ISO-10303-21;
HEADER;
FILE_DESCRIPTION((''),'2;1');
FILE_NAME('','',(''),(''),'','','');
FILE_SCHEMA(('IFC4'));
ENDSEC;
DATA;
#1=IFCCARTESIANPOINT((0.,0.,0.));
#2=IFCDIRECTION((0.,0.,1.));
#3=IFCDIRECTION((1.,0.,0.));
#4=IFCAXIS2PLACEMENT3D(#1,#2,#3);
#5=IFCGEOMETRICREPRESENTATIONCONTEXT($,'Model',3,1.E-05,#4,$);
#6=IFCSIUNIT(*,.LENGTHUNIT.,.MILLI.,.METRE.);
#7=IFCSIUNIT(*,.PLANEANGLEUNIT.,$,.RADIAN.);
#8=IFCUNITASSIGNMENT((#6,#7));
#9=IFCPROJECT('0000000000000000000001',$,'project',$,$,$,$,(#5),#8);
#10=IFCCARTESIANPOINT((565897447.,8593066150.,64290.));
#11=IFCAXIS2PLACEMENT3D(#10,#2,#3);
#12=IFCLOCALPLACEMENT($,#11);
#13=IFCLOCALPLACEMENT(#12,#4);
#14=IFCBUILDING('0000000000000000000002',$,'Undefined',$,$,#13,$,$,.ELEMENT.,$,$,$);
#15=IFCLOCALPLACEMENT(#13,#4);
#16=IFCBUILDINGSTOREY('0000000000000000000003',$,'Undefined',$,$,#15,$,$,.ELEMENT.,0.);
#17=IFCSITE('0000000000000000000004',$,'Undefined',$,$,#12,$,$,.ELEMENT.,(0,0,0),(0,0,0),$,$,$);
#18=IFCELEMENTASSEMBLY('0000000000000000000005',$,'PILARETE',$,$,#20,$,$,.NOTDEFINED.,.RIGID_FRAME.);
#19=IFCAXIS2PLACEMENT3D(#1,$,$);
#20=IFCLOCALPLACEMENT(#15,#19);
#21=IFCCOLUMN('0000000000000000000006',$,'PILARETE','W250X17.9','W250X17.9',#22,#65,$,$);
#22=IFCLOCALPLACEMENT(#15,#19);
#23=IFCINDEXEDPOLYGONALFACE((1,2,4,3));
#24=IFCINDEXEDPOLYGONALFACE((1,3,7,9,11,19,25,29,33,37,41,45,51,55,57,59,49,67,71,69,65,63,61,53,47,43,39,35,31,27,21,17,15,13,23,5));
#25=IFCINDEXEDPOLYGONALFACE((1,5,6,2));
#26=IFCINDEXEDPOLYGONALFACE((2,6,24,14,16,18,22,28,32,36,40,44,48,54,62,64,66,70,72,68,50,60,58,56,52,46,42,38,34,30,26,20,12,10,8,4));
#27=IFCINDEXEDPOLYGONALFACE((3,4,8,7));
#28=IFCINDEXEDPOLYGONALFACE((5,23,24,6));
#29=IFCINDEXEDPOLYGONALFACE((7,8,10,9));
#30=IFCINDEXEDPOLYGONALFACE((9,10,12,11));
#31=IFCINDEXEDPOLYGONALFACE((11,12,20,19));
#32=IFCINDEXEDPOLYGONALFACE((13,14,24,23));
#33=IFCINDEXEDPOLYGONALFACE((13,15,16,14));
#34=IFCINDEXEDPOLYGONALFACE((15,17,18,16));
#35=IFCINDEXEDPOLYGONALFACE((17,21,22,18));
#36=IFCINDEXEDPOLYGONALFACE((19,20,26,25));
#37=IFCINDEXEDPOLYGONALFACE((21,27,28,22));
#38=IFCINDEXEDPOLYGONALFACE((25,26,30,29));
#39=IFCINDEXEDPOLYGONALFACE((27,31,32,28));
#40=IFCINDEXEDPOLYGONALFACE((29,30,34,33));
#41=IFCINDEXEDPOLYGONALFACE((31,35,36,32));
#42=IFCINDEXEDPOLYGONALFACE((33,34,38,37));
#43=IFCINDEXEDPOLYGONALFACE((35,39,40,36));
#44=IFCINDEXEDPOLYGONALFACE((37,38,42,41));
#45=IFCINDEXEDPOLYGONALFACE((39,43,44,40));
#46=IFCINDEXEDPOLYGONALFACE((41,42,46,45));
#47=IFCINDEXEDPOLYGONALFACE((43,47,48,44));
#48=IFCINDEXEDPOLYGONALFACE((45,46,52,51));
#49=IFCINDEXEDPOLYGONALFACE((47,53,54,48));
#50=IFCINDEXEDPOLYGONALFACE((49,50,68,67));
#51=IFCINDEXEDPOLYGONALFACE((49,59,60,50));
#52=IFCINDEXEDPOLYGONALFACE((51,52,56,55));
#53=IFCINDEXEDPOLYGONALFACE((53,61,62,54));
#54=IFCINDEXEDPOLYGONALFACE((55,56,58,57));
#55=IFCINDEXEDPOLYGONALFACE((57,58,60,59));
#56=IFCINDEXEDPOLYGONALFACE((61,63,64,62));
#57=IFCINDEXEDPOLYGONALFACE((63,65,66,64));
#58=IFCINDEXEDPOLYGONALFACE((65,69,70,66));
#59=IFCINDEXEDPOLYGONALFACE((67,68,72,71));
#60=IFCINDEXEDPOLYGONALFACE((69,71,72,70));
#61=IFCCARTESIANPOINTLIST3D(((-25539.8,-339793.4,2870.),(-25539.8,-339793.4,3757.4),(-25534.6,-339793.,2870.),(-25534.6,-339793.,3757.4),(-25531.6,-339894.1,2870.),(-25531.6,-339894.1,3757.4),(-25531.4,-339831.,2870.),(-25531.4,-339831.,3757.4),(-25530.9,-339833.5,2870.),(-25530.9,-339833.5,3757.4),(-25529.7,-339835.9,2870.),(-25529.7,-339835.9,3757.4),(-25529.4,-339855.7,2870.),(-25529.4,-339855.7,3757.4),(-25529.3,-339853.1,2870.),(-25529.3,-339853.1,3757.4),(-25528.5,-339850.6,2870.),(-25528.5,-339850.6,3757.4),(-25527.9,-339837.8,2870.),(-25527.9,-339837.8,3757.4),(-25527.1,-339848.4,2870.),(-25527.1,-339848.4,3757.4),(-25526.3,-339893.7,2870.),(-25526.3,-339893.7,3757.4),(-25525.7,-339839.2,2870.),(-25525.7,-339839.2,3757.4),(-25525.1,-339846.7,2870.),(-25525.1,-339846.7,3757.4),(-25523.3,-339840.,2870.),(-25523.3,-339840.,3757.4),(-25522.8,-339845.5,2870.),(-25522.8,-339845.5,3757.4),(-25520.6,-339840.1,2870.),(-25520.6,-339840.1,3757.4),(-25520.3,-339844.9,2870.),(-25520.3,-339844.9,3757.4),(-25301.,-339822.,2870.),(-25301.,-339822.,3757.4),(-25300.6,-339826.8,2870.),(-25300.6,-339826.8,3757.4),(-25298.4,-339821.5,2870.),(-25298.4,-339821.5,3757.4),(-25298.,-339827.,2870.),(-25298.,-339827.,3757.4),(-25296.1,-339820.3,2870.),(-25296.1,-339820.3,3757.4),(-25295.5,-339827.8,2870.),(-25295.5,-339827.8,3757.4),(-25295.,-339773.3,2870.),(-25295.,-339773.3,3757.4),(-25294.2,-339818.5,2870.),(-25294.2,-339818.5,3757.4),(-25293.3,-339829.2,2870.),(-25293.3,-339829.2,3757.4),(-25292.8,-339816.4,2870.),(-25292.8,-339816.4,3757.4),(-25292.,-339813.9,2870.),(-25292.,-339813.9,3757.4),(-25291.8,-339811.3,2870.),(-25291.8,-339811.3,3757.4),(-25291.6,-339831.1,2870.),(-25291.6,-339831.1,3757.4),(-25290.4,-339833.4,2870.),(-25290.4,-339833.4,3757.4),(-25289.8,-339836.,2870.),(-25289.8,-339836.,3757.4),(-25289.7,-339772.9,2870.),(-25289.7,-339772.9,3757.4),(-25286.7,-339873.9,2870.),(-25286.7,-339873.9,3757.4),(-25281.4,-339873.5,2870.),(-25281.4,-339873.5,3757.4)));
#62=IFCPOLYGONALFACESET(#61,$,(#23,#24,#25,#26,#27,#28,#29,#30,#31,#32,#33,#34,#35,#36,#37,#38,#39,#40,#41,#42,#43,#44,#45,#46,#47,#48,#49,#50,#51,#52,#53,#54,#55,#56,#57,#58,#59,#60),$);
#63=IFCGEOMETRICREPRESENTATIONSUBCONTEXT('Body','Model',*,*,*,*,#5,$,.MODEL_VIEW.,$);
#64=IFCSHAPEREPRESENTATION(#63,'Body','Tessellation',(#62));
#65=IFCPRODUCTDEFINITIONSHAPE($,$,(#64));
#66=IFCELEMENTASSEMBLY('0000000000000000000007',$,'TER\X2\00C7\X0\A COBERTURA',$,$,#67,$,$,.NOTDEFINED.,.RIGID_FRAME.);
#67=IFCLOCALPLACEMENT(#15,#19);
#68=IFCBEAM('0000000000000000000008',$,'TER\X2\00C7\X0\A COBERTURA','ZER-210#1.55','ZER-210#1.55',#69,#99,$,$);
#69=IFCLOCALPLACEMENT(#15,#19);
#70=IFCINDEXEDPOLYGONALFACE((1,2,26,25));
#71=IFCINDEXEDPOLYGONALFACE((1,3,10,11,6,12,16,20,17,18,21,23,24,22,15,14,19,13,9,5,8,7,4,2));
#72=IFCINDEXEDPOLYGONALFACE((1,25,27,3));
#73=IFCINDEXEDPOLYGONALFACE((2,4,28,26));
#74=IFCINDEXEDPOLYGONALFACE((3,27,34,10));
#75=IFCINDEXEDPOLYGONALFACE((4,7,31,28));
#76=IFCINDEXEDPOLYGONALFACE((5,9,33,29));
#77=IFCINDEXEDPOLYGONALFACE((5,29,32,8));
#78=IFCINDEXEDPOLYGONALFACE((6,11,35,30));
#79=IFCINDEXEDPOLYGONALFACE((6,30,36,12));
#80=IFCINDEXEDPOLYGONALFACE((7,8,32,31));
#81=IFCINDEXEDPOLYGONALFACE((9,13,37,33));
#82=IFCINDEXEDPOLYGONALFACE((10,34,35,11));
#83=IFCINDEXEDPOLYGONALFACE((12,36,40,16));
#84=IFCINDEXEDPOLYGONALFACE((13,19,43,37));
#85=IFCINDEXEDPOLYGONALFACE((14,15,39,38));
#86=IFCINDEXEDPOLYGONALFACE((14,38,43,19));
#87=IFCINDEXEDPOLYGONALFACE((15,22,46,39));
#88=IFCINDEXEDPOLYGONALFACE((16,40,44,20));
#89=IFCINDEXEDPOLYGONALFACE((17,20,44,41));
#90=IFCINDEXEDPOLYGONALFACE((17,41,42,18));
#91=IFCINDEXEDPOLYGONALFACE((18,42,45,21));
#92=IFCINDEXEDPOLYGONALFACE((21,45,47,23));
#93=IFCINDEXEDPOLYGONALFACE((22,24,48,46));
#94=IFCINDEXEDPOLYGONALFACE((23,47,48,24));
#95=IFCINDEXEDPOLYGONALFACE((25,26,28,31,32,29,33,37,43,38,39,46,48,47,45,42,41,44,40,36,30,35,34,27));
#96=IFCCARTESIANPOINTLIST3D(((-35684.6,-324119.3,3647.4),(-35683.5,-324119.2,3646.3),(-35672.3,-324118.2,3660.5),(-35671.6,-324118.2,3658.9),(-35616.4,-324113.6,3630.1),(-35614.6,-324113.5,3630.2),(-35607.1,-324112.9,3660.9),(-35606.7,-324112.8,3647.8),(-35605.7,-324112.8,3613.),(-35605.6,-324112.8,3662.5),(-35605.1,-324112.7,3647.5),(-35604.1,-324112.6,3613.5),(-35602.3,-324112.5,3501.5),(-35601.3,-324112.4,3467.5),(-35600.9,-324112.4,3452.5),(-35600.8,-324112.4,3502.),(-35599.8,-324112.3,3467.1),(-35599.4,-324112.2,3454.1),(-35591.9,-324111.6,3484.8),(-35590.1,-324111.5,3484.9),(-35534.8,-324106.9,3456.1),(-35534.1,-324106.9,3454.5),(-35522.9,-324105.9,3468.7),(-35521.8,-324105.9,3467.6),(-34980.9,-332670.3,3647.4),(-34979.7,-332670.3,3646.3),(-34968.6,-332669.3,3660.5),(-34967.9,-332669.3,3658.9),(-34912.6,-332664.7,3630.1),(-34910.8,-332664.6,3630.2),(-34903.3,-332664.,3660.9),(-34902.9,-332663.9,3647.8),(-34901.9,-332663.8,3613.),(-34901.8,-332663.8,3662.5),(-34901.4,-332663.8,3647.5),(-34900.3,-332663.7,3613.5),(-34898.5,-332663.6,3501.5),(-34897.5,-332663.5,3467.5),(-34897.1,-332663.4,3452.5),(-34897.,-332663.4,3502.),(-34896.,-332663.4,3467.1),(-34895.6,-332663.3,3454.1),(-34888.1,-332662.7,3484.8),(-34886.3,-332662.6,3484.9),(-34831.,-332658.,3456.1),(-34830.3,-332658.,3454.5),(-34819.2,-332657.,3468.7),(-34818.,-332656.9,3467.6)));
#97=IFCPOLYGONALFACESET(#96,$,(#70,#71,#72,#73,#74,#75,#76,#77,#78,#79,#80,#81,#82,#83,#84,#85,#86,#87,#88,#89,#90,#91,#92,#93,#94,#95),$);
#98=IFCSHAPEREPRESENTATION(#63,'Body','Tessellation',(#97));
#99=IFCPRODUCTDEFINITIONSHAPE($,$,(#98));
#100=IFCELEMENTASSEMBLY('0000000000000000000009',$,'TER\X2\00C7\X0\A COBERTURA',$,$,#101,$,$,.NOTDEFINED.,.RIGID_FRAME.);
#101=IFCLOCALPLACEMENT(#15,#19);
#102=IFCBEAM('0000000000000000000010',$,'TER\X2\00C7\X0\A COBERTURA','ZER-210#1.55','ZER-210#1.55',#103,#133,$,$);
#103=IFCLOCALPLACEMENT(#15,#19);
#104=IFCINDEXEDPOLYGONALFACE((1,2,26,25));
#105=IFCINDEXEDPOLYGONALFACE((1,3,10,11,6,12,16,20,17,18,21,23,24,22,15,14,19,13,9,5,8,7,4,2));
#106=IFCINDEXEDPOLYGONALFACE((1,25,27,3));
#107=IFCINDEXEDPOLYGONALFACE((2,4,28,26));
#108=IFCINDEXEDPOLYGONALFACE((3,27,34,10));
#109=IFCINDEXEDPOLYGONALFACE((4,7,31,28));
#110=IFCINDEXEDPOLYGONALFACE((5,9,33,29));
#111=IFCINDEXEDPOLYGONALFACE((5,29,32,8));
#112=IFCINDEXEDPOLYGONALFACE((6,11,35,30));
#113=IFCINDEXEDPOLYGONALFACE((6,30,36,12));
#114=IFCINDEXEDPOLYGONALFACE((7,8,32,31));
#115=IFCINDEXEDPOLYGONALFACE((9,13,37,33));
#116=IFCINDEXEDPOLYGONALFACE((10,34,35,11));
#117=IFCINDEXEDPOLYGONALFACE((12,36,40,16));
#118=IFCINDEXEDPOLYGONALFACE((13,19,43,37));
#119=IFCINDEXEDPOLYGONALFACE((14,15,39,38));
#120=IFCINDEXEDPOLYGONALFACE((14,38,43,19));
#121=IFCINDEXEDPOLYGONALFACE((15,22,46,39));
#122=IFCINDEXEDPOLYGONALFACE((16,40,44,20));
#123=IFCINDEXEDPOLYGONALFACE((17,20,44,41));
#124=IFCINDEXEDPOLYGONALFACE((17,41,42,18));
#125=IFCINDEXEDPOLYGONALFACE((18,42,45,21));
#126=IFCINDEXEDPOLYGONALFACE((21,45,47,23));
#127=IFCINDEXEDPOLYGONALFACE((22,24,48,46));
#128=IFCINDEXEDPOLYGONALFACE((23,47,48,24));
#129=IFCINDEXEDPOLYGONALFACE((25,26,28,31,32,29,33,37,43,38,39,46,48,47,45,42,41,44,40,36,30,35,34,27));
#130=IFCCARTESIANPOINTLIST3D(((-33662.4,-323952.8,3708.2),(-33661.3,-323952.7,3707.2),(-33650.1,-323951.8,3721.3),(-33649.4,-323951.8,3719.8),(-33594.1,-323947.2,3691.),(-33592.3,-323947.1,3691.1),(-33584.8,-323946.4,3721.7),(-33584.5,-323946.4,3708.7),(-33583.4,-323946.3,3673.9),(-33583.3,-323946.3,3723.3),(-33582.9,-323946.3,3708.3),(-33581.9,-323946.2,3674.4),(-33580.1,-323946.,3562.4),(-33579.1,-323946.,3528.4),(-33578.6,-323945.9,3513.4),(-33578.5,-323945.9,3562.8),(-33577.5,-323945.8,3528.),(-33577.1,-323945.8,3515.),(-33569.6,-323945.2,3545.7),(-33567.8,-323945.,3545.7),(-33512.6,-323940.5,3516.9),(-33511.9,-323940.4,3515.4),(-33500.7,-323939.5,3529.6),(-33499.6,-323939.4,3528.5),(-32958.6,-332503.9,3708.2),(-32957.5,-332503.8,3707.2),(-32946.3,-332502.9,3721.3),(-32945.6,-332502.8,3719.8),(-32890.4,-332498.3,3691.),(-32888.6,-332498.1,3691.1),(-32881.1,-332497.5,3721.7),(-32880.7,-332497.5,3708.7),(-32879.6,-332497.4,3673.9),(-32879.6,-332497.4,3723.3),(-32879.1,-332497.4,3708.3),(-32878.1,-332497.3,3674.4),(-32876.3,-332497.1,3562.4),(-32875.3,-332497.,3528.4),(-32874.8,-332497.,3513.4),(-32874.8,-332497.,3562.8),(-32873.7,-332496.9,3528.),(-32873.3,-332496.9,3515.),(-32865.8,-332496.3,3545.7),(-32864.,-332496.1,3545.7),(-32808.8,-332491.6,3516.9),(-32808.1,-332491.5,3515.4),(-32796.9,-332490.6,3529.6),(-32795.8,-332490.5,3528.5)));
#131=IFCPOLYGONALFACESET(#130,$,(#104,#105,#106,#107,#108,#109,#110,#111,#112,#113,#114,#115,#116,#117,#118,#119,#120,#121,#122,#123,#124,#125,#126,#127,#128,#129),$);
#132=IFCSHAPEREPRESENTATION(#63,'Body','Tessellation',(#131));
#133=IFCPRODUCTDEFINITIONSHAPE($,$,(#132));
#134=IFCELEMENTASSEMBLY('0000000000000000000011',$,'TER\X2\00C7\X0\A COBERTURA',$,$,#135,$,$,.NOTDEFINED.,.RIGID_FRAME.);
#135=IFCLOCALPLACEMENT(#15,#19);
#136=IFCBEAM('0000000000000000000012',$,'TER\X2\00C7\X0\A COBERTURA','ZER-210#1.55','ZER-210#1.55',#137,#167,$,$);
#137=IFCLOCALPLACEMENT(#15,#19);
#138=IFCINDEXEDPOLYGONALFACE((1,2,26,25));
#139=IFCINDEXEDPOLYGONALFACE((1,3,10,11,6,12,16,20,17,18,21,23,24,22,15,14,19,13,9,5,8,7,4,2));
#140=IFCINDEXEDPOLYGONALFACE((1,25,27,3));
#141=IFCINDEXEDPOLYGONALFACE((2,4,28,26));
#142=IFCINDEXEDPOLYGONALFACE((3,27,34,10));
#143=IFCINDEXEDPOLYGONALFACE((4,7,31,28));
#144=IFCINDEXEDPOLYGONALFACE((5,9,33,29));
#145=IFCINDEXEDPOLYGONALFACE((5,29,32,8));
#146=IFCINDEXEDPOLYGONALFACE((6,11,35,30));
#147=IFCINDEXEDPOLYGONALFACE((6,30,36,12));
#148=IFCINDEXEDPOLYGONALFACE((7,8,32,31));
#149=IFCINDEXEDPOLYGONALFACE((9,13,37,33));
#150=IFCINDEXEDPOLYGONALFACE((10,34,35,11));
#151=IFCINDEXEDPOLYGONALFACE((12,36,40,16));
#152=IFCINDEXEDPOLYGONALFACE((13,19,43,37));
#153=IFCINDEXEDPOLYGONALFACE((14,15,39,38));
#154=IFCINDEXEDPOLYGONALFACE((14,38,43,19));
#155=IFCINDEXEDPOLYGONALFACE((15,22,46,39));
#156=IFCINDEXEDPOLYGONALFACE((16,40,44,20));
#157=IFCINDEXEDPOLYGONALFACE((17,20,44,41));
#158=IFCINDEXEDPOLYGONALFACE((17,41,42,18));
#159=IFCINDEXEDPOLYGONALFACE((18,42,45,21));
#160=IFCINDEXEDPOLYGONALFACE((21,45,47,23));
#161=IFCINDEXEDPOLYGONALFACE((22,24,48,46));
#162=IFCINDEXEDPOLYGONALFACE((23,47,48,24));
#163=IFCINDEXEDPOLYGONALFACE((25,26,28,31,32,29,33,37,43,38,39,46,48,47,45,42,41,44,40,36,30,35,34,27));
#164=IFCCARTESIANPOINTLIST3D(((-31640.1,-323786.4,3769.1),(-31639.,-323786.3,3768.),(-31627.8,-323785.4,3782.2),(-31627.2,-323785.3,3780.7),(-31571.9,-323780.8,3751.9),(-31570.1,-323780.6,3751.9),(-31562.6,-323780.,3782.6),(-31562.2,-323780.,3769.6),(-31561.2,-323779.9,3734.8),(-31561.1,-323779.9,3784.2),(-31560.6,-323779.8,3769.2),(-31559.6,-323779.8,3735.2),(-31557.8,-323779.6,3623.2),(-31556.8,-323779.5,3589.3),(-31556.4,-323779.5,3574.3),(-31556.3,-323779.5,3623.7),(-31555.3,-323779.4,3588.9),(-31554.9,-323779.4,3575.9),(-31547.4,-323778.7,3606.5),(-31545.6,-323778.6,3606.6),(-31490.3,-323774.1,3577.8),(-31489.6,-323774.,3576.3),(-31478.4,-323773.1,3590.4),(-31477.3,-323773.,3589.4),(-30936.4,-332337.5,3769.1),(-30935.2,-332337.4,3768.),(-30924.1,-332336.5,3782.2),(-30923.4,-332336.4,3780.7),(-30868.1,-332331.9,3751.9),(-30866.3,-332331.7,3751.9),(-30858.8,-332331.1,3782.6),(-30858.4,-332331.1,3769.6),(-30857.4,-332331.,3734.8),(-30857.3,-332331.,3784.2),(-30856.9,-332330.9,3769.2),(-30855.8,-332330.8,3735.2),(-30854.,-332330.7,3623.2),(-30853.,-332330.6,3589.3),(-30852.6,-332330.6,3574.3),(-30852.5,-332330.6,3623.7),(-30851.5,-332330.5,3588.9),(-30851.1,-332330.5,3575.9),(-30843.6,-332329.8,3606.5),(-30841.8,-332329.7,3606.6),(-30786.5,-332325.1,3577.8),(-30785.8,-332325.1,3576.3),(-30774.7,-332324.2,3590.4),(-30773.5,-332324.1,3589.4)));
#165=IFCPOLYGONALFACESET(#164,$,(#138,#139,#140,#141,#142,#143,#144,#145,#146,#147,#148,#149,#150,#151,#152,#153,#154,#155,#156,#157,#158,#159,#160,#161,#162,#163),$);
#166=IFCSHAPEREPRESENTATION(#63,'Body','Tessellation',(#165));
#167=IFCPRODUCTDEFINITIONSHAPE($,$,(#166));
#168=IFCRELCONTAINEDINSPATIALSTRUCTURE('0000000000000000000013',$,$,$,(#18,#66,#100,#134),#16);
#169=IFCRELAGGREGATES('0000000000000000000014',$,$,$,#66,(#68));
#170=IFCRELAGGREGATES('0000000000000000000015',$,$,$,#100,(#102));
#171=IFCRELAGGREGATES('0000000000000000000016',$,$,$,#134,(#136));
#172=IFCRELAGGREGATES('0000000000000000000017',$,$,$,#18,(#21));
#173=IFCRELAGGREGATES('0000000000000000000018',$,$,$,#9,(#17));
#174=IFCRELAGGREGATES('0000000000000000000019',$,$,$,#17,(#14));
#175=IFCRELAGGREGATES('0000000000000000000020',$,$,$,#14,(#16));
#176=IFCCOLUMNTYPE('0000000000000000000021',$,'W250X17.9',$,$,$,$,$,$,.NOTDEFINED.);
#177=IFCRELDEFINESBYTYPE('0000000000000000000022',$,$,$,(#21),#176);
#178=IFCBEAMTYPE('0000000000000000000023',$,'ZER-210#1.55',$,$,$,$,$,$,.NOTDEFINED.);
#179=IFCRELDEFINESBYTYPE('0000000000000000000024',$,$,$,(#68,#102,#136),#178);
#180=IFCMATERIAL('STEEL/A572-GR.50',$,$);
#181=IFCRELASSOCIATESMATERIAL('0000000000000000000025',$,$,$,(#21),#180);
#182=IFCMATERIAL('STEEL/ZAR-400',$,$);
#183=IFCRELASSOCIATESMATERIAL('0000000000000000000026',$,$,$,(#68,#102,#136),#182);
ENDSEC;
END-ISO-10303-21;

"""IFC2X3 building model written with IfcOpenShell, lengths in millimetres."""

from ifc_helpers import new_model, si_unit, frame, origin_with_axes, origin_2d_with_axis, place, context, subcontext, project, spatial, polyline, i_section, outline, extrude, material, type_object, element, aggregate, save


model = new_model("IFC2X3")

# Units and contexts
model_context = context("Model", 3, precision=1e-05, world=origin_with_axes())
body_context = subcontext(model_context, "Body", "Model", "MODEL_VIEW")
ifc_project = project(units=[si_unit("LENGTHUNIT", "METRE", prefix="MILLI"), si_unit("PLANEANGLEUNIT", "RADIAN")], contexts=[model_context])

# Site, building, storey
site_placement = place(None, frame((565897447.0, 8593066150.0, 64290.0), z_axis=(0.0, 0.0, 1.0), x_axis=(1.0, 0.0, 0.0)))
site = spatial("IfcSite", under=ifc_project, at=site_placement, Name="Undefined", CompositionType="ELEMENT", RefLatitude=(0, 0, 0), RefLongitude=(0, 0, 0))
building_placement = place(site_placement, origin_with_axes())
building = spatial("IfcBuilding", under=site, at=building_placement, Name="Undefined", CompositionType="ELEMENT")
storey_placement = place(building_placement, origin_with_axes())
storey = spatial("IfcBuildingStorey", under=building, at=storey_placement, Name="Undefined", CompositionType="ELEMENT", Elevation=0.0)

# Element assembly, column
assembly_1_placement = place(storey_placement, origin_with_axes())
assembly_1 = element("IfcElementAssembly", 1, at=assembly_1_placement, inside=storey, Name="PILARETE", AssemblyPlace="NOTDEFINED", PredefinedType="RIGID_FRAME")
ifc_material_1 = material(Name="STEEL/A572-GR.50")
column_type = type_object("IfcColumnType", Name="W250X17.9", PredefinedType="NOTDEFINED")
column_placement = place(assembly_1_placement, frame((-25410.6, -339833.5, 2870.0), z_axis=(0.0, 0.0, 1.0), x_axis=(0.99663, 0.082025, 0.0)))
column = element("IfcColumn", 2, at=column_placement, type_object=column_type, material=ifc_material_1, Name="PILARETE", Description="W250X17.9", ObjectType="W250X17.9", context=body_context, shape_type="SweptSolid", body=[
    extrude(i_section(OverallWidth=101.0, OverallDepth=251.0, WebThickness=4.8, FlangeThickness=5.3, FilletRadius=10.0, at=origin_2d_with_axis()), frame((0.0, 0.0, 887.4), z_axis=(0.0, 0.0, -1.0), x_axis=(0.0, 1.0, 0.0)), (0.0, 0.0, 1.0), 887.4),
])

# Element assemblies, beams
assembly_2_placement = place(storey_placement, origin_with_axes())
assembly_2 = element("IfcElementAssembly", 3, at=assembly_2_placement, inside=storey, Name="TERÇA COBERTURA", AssemblyPlace="NOTDEFINED", PredefinedType="RIGID_FRAME")
ifc_material_2 = material(Name="STEEL/ZAR-400")
beam_type_1 = type_object("IfcBeamType", Name="ZER-210#1.55", PredefinedType="NOTDEFINED")
beam_1_placement = place(assembly_2_placement, frame((-34899.4, -332663.6, 3557.5), z_axis=(-0.029885, -0.00246, 0.99955), x_axis=(-0.082025, 0.99663, 0.0)))
beam_1 = element("IfcBeam", 4, at=beam_1_placement, type_object=beam_type_1, material=ifc_material_2, Name="TERÇA COBERTURA", Description="ZER-210#1.55", ObjectType="ZER-210#1.55", context=body_context, shape_type="SweptSolid", body=[
    extrude(outline(polyline([(65.6, -103.4), (77.9, -91.2), (79.0, -92.3), (66.2, -105.0), (-0.8, -105.0), (-0.8, -90.0), (9.2, -73.0), (-0.8, -56.0), (-0.8, 55.6), (-11.0, 73.0), (-0.8, 90.4), (-0.8, 103.5), (-65.6, 103.4), (-77.9, 91.2), (-79.0, 92.3), (-66.2, 105.0), (0.8, 105.0), (0.8, 90.0), (-9.2, 73.0), (0.8, 56.0), (0.8, -55.6), (11.0, -73.0), (0.8, -90.4), (0.8, -103.5), (65.6, -103.4)])), frame((8580.0, 0.0, 0.0), z_axis=(-1.0, 0.0, 0.0), x_axis=(0.0, -1.0, 0.0)), (0.0, 0.0, 1.0), 8580.0),
])
aggregate(assembly_2, [beam_1])
assembly_3_placement = place(storey_placement, origin_with_axes())
assembly_3 = element("IfcElementAssembly", 5, at=assembly_3_placement, inside=storey, Name="TERÇA COBERTURA", AssemblyPlace="NOTDEFINED", PredefinedType="RIGID_FRAME")
beam_2_placement = place(assembly_3_placement, frame((-32877.2, -332497.2, 3618.4), z_axis=(-0.029885, -0.00246, 0.99955), x_axis=(-0.082025, 0.99663, 0.0)))
beam_2 = element("IfcBeam", 6, at=beam_2_placement, type_object=beam_type_1, material=ifc_material_2, Name="TERÇA COBERTURA", Description="ZER-210#1.55", ObjectType="ZER-210#1.55", context=body_context, shape_type="SweptSolid", body=[
    extrude(outline(polyline([(65.6, -103.4), (77.9, -91.2), (79.0, -92.3), (66.2, -105.0), (-0.8, -105.0), (-0.8, -90.0), (9.2, -73.0), (-0.8, -56.0), (-0.8, 55.6), (-11.0, 73.0), (-0.8, 90.4), (-0.8, 103.5), (-65.6, 103.4), (-77.9, 91.2), (-79.0, 92.3), (-66.2, 105.0), (0.8, 105.0), (0.8, 90.0), (-9.2, 73.0), (0.8, 56.0), (0.8, -55.6), (11.0, -73.0), (0.8, -90.4), (0.8, -103.5), (65.6, -103.4)])), frame((8580.0, 0.0, 0.0), z_axis=(-1.0, 0.0, 0.0), x_axis=(0.0, -1.0, 0.0)), (0.0, 0.0, 1.0), 8580.0),
])
aggregate(assembly_3, [beam_2])
assembly_4_placement = place(storey_placement, origin_with_axes())
assembly_4 = element("IfcElementAssembly", 7, at=assembly_4_placement, inside=storey, Name="TERÇA COBERTURA", AssemblyPlace="NOTDEFINED", PredefinedType="RIGID_FRAME")
beam_3_placement = place(assembly_4_placement, frame((-30854.9, -332330.8, 3679.2), z_axis=(-0.029885, -0.00246, 0.99955), x_axis=(-0.082025, 0.99663, 0.0)))
beam_3 = element("IfcBeam", 8, at=beam_3_placement, type_object=beam_type_1, material=ifc_material_2, Name="TERÇA COBERTURA", Description="ZER-210#1.55", ObjectType="ZER-210#1.55", context=body_context, shape_type="SweptSolid", body=[
    extrude(outline(polyline([(65.6, -103.4), (77.9, -91.2), (79.0, -92.3), (66.2, -105.0), (-0.8, -105.0), (-0.8, -90.0), (9.2, -73.0), (-0.8, -56.0), (-0.8, 55.6), (-11.0, 73.0), (-0.8, 90.4), (-0.8, 103.5), (-65.6, 103.4), (-77.9, 91.2), (-79.0, 92.3), (-66.2, 105.0), (0.8, 105.0), (0.8, 90.0), (-9.2, 73.0), (0.8, 56.0), (0.8, -55.6), (11.0, -73.0), (0.8, -90.4), (0.8, -103.5), (65.6, -103.4)])), frame((8580.0, 0.0, 0.0), z_axis=(-1.0, 0.0, 0.0), x_axis=(0.0, -1.0, 0.0)), (0.0, 0.0, 1.0), 8580.0),
])
aggregate(assembly_4, [beam_3])

aggregate(assembly_1, [column])

save(model, "model.ifc")
